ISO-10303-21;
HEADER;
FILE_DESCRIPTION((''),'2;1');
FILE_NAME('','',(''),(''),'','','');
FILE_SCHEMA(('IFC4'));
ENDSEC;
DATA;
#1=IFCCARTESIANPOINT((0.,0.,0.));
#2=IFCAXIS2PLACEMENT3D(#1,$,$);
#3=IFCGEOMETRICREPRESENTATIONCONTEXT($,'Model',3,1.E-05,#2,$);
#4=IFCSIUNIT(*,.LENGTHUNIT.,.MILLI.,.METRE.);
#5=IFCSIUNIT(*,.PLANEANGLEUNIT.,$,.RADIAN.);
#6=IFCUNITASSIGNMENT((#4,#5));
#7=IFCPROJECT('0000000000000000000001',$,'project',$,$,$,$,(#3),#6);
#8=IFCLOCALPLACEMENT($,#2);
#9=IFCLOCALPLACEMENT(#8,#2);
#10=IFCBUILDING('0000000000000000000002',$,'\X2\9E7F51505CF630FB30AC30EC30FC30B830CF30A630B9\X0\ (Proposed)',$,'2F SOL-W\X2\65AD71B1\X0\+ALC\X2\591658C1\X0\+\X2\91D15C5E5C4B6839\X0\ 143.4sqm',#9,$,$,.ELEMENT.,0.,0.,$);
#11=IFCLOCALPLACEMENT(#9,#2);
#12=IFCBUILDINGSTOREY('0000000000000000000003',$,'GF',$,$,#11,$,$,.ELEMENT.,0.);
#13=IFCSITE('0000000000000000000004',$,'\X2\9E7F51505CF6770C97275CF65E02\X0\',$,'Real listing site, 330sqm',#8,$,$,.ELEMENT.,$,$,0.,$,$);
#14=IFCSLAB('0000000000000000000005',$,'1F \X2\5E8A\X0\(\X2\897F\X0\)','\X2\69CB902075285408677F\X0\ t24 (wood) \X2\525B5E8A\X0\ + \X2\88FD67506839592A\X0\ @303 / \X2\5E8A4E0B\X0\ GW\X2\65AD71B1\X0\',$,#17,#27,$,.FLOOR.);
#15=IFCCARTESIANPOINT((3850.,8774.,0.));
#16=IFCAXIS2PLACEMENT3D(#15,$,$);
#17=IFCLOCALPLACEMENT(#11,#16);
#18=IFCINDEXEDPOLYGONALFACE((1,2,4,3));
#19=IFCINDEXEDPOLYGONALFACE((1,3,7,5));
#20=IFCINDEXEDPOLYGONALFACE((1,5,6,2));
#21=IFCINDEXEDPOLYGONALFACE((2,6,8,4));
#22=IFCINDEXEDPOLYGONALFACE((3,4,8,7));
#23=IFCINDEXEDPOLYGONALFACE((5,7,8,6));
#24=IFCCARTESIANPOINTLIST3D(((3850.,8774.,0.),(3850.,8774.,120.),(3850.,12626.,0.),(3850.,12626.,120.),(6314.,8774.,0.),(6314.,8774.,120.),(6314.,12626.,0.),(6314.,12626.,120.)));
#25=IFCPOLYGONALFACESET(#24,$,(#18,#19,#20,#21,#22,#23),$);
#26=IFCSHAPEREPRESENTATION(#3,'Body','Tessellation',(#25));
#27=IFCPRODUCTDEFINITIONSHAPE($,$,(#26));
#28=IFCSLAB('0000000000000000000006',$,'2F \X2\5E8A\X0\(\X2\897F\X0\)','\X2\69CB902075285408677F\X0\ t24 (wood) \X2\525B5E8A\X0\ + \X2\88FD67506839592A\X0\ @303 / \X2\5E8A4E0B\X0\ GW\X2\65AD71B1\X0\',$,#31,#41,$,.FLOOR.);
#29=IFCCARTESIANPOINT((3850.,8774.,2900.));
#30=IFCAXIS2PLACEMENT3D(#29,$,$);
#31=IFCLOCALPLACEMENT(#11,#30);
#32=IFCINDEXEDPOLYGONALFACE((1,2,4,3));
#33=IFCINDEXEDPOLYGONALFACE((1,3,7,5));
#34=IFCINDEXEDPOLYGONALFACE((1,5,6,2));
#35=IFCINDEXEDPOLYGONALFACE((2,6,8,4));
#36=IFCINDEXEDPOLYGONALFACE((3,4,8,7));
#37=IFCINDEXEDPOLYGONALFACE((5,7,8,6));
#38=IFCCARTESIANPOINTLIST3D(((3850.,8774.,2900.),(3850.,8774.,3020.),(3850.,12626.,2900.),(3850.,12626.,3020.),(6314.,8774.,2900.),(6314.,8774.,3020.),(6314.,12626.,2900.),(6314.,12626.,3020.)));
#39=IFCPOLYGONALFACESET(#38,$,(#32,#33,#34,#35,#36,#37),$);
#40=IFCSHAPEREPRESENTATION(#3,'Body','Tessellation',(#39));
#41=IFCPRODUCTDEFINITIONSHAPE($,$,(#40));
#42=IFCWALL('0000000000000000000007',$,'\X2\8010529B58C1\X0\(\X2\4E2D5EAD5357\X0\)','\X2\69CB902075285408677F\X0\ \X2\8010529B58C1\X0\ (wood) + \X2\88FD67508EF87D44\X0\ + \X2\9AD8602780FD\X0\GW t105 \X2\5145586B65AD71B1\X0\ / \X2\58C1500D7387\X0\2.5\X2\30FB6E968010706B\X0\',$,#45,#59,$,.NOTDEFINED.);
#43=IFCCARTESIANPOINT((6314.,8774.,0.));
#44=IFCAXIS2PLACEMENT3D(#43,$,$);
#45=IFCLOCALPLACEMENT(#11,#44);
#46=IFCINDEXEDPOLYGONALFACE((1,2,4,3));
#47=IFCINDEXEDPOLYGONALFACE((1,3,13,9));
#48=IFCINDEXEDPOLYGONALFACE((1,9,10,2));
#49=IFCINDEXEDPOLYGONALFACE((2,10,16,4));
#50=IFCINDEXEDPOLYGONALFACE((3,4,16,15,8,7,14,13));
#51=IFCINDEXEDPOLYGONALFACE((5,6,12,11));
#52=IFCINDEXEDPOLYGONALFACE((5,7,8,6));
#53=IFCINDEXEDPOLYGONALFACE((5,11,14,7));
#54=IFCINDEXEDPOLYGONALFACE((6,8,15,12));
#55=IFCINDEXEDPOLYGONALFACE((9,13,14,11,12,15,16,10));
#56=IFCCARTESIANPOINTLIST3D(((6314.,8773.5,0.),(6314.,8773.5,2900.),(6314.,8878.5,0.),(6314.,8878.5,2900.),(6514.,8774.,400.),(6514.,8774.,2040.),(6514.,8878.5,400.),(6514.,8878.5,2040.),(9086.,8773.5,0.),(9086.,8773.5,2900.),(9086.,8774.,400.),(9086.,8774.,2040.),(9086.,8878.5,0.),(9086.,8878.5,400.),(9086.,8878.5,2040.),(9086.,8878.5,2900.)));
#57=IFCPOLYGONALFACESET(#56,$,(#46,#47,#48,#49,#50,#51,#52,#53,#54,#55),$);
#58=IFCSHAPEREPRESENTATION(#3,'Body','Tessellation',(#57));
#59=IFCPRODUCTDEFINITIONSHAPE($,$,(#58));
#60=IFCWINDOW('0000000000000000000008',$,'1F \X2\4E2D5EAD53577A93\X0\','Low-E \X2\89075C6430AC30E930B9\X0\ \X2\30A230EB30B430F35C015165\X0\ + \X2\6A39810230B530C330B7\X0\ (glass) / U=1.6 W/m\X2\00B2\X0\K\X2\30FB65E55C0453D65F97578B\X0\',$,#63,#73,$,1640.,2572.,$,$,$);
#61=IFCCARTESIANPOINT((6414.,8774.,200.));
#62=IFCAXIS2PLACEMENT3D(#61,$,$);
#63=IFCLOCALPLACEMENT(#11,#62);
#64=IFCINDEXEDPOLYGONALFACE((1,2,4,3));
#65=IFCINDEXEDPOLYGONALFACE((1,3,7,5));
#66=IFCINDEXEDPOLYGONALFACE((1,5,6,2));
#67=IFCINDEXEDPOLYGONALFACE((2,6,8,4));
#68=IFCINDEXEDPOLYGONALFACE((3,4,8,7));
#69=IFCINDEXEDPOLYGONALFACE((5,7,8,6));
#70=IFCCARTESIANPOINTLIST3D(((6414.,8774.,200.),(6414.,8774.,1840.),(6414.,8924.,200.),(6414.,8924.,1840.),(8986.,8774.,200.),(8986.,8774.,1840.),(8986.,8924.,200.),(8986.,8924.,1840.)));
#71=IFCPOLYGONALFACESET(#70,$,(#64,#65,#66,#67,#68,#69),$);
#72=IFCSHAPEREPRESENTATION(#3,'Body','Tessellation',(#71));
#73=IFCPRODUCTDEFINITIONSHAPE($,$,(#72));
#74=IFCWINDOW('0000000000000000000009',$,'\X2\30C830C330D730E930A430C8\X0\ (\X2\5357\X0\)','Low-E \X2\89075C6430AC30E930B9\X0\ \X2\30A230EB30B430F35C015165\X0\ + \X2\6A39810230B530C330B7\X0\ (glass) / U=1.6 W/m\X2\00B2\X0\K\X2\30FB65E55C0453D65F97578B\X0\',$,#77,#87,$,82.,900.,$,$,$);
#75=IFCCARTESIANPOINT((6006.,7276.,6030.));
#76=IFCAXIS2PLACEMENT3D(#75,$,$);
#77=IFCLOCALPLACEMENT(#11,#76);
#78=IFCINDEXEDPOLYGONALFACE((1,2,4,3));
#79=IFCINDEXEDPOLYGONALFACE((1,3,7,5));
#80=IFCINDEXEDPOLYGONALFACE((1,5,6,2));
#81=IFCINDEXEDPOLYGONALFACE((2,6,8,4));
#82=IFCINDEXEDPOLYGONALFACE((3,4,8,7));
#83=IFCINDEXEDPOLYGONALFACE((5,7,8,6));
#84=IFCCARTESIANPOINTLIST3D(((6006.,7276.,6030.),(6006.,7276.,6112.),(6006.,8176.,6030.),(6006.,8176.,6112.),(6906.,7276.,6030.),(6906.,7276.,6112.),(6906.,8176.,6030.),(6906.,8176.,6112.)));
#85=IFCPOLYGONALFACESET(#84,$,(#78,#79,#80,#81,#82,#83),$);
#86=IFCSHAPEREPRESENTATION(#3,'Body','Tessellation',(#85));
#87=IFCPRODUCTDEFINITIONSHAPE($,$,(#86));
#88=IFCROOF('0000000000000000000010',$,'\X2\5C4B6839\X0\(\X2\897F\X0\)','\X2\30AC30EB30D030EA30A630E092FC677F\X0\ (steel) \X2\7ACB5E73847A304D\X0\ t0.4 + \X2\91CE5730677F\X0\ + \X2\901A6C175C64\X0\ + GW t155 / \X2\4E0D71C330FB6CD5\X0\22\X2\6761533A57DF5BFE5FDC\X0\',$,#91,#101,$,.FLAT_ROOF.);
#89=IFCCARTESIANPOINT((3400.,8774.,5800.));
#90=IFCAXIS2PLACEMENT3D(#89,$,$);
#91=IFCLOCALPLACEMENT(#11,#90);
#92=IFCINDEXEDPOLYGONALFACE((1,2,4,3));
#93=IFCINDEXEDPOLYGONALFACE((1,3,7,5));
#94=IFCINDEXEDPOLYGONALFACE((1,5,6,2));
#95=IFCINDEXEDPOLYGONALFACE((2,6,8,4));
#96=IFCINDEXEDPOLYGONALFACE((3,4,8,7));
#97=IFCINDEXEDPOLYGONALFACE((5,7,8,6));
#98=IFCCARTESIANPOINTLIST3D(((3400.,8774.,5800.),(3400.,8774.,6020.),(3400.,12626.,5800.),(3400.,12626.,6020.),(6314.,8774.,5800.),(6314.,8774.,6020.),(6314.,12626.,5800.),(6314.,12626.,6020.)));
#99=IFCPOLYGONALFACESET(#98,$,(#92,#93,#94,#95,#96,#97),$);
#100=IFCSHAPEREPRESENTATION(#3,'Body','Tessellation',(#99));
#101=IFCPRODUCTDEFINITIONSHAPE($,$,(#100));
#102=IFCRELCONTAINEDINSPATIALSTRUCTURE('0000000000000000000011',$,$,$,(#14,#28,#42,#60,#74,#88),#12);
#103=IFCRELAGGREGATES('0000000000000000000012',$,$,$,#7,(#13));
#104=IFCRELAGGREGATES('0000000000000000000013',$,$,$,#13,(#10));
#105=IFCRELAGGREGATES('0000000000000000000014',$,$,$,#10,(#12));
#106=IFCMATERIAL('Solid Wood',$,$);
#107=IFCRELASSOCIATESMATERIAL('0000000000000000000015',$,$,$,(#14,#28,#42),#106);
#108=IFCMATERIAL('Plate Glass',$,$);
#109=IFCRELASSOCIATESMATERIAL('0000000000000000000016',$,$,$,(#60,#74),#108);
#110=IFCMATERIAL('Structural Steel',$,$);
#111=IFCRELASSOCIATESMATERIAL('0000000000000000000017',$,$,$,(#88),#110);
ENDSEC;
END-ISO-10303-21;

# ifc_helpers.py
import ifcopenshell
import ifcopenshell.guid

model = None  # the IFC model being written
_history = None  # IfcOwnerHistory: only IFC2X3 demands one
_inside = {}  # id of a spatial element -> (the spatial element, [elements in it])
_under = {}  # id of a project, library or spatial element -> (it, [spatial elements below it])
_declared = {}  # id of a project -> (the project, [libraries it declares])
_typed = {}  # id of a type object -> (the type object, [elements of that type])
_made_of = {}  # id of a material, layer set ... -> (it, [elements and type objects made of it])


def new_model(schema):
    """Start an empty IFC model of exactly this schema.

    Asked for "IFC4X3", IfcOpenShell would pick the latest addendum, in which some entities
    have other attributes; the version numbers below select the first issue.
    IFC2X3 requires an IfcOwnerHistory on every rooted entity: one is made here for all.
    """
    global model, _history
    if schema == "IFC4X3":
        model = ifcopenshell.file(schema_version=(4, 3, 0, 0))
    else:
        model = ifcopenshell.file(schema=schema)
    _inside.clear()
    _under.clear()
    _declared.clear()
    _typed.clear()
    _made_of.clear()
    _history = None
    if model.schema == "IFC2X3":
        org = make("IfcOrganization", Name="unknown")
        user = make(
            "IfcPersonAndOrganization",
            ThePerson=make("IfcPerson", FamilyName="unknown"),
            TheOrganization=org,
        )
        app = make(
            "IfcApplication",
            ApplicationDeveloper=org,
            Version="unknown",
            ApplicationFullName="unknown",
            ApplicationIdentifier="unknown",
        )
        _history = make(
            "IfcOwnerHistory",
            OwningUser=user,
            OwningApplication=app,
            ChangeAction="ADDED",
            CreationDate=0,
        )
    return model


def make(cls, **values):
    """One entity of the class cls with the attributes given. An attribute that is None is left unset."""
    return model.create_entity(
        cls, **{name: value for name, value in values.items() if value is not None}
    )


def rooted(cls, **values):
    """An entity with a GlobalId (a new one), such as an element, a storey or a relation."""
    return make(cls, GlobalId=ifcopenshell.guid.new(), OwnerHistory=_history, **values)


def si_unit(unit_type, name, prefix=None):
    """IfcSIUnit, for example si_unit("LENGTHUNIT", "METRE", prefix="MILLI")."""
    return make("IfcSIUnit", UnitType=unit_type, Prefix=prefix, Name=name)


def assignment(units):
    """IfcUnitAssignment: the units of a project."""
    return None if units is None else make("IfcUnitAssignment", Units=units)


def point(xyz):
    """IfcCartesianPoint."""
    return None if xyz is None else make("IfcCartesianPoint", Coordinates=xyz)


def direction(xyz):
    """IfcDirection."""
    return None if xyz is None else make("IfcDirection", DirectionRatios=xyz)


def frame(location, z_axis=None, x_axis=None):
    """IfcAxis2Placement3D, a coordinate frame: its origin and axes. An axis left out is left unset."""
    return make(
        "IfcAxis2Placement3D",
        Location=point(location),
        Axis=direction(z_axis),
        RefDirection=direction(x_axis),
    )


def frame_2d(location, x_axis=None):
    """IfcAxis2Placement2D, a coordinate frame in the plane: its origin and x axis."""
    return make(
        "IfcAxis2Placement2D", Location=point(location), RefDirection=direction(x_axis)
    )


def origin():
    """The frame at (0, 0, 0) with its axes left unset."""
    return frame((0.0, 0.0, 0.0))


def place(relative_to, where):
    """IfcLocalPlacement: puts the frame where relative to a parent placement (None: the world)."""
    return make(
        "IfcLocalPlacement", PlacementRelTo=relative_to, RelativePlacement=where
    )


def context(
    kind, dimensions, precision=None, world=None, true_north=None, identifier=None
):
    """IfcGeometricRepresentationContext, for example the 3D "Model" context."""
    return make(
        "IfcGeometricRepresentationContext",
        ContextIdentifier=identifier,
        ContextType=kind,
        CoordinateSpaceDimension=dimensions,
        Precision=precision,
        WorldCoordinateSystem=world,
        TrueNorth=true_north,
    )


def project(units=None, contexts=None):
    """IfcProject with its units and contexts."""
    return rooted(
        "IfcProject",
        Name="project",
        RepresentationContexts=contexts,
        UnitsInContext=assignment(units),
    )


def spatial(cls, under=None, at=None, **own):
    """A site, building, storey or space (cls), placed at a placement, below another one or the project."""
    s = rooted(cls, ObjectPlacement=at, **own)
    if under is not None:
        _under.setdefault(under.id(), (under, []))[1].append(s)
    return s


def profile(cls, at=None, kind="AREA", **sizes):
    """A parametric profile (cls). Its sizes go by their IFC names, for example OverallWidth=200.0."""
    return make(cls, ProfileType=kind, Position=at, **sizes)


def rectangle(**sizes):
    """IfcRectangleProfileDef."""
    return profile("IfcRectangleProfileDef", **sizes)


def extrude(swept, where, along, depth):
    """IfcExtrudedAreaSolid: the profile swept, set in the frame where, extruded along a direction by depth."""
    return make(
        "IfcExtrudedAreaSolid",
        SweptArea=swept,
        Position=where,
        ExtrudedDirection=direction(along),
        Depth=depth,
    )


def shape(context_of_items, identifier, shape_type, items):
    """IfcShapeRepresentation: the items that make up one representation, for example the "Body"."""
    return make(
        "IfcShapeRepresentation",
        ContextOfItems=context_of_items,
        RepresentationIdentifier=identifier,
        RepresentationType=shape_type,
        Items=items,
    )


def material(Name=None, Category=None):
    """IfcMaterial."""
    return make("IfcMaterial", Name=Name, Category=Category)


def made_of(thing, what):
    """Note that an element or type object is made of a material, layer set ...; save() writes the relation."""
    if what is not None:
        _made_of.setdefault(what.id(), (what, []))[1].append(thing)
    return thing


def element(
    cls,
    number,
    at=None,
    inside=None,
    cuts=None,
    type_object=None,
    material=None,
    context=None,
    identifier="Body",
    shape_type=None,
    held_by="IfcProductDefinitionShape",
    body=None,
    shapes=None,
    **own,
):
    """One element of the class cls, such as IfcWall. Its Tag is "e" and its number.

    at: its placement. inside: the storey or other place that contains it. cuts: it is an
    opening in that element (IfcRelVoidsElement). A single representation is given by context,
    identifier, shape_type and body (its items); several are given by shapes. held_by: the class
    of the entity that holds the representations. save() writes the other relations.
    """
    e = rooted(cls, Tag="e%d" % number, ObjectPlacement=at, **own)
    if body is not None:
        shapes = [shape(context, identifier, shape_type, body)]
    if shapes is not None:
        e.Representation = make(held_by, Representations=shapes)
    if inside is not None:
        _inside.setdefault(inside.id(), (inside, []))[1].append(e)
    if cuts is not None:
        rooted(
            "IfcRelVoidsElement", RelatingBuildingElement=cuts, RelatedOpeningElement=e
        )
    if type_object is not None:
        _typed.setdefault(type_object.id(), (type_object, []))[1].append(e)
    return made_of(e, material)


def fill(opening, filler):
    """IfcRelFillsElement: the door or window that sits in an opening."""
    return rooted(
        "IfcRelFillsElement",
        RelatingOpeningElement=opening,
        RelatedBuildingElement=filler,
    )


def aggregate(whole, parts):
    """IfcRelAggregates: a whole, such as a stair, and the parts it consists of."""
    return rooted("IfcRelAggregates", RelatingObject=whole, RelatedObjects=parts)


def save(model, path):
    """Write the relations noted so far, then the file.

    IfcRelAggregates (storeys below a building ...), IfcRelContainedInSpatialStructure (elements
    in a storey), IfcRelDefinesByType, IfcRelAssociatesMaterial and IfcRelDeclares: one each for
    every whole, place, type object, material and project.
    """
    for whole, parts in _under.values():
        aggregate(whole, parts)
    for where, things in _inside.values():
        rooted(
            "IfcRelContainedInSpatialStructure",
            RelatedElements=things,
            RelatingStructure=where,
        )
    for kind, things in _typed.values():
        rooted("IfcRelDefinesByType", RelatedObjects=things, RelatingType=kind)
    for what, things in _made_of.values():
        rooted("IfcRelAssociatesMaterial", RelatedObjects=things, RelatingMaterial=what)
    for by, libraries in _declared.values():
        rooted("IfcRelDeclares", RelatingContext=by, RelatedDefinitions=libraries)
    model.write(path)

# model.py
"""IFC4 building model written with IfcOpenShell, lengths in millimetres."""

from ifc_helpers import new_model, si_unit, frame, frame_2d, origin, place, context, project, spatial, rectangle, extrude, material, element, fill, save


model = new_model("IFC4")

# Units and contexts
model_context = context("Model", 3, precision=1e-05, world=origin())
ifc_project = project(units=[si_unit("LENGTHUNIT", "METRE", prefix="MILLI"), si_unit("PLANEANGLEUNIT", "RADIAN")], contexts=[model_context])

# Site, building, storey
site_placement = place(None, origin())
site = spatial("IfcSite", under=ifc_project, at=site_placement, Name="鹿児島県霧島市", ObjectType="Real listing site, 330sqm", CompositionType="ELEMENT", RefElevation=0.0)
building_placement = place(site_placement, origin())
building = spatial("IfcBuilding", under=site, at=building_placement, Name="鹿児島・ガレージハウス (Proposed)", ObjectType="2F SOL-W断熱+ALC外壁+金属屋根 143.4sqm", CompositionType="ELEMENT", ElevationOfRefHeight=0.0, ElevationOfTerrain=0.0)
storey_placement = place(building_placement, origin())
storey = spatial("IfcBuildingStorey", under=building, at=storey_placement, Name="GF", CompositionType="ELEMENT", Elevation=0.0)

# Shared definitions
ifc_material_1 = material(Name="Solid Wood")

# Slabs
slab_1_placement = place(storey_placement, frame((3850.0, 8774.0, 0.0)))
element("IfcSlab", 1, at=slab_1_placement, inside=storey, material=ifc_material_1, Name="1F 床(西)", Description="構造用合板 t24 (wood) 剛床 + 製材根太 @303 / 床下 GW断熱", PredefinedType="FLOOR", context=model_context, shape_type="SweptSolid", body=[
    extrude(rectangle(XDim=2464.0, YDim=3852.0, at=frame_2d((1232.0, 1926.0))), frame((3850.0, 8774.0, 0.0)), (0.0, 0.0, 1.0), 120.0),
])
slab_2_placement = place(storey_placement, frame((3850.0, 8774.0, 2900.0)))
element("IfcSlab", 2, at=slab_2_placement, inside=storey, material=ifc_material_1, Name="2F 床(西)", Description="構造用合板 t24 (wood) 剛床 + 製材根太 @303 / 床下 GW断熱", PredefinedType="FLOOR", context=model_context, shape_type="SweptSolid", body=[
    extrude(rectangle(XDim=2464.0, YDim=3852.0, at=frame_2d((1232.0, 1926.0))), frame((3850.0, 8774.0, 2900.0)), (0.0, 0.0, 1.0), 120.0),
])

# Wall, opening, window
wall_1_placement = place(storey_placement, frame((6314.0, 8774.0, 0.0)))
wall_1 = element("IfcWall", 3, at=wall_1_placement, inside=storey, material=ifc_material_1, Name="耐力壁(中庭南)", Description="構造用合板 耐力壁 (wood) + 製材軸組 + 高性能GW t105 充填断熱 / 壁倍率2.5・準耐火", PredefinedType="NOTDEFINED", context=model_context, shape_type="SweptSolid", body=[
    extrude(rectangle(XDim=2772.0, YDim=105.0, at=frame_2d((1386.0, 52.0))), frame((6314.0, 8774.0, 0.0)), (0.0, 0.0, 1.0), 2900.0),
])
opening_placement = place(storey_placement, frame((6414.0, 8774.0, 200.0)))
opening = element("IfcOpeningElement", 4, at=opening_placement, cuts=wall_1, PredefinedType="NOTDEFINED", context=model_context, shape_type="SweptSolid", body=[
    extrude(rectangle(XDim=2572.0, YDim=150.0, at=frame_2d((1286.0, 75.0))), frame((6414.0, 8774.0, 200.0)), (0.0, 0.0, 1.0), 1640.0),
])
ifc_material_2 = material(Name="Plate Glass")
window_1_placement = place(storey_placement, frame((6414.0, 8774.0, 200.0)))
window_1 = element("IfcWindow", 5, at=window_1_placement, inside=storey, material=ifc_material_2, Name="1F 中庭南窓", Description="Low-E 複層ガラス アルゴン封入 + 樹脂サッシ (glass) / U=1.6 W/m²K・日射取得型", OverallHeight=1640.0, OverallWidth=2572.0, context=model_context, shape_type="SweptSolid", body=[
    extrude(rectangle(XDim=2572.0, YDim=150.0, at=frame_2d((1286.0, 75.0))), frame((6414.0, 8774.0, 200.0)), (0.0, 0.0, 1.0), 1640.0),
])
fill(opening, window_1)

# Window
window_2_placement = place(storey_placement, frame((6006.0, 7276.0, 6030.0)))
element("IfcWindow", 6, at=window_2_placement, inside=storey, material=ifc_material_2, Name="トップライト (南)", Description="Low-E 複層ガラス アルゴン封入 + 樹脂サッシ (glass) / U=1.6 W/m²K・日射取得型", OverallHeight=82.0, OverallWidth=900.0, context=model_context, shape_type="SweptSolid", body=[
    extrude(rectangle(XDim=900.0, YDim=900.0, at=frame_2d((450.0, 450.0))), frame((6006.0, 7276.0, 6030.0)), (0.0, 0.0, 1.0), 82.0),
])

# Roof
ifc_material_3 = material(Name="Structural Steel")
for number, where, name in (
    (7, (3400.0, 8774.0, 5800.0), "屋根(西)"),
):
    element("IfcRoof", number, at=place(storey_placement, frame(where)), inside=storey, material=ifc_material_3, Name=name, Description="ガルバリウム鋼板 (steel) 立平葺き t0.4 + 野地板 + 通気層 + GW t155 / 不燃・法22条区域対応", PredefinedType="FLAT_ROOF", context=model_context, shape_type="SweptSolid", body=[
        extrude(rectangle(XDim=2914.0, YDim=3852.0, at=frame_2d((1457.0, 1926.0))), frame((3400.0, 8774.0, 5800.0)), (0.0, 0.0, 1.0), 220.0),
    ])

save(model, "model.ifc")
